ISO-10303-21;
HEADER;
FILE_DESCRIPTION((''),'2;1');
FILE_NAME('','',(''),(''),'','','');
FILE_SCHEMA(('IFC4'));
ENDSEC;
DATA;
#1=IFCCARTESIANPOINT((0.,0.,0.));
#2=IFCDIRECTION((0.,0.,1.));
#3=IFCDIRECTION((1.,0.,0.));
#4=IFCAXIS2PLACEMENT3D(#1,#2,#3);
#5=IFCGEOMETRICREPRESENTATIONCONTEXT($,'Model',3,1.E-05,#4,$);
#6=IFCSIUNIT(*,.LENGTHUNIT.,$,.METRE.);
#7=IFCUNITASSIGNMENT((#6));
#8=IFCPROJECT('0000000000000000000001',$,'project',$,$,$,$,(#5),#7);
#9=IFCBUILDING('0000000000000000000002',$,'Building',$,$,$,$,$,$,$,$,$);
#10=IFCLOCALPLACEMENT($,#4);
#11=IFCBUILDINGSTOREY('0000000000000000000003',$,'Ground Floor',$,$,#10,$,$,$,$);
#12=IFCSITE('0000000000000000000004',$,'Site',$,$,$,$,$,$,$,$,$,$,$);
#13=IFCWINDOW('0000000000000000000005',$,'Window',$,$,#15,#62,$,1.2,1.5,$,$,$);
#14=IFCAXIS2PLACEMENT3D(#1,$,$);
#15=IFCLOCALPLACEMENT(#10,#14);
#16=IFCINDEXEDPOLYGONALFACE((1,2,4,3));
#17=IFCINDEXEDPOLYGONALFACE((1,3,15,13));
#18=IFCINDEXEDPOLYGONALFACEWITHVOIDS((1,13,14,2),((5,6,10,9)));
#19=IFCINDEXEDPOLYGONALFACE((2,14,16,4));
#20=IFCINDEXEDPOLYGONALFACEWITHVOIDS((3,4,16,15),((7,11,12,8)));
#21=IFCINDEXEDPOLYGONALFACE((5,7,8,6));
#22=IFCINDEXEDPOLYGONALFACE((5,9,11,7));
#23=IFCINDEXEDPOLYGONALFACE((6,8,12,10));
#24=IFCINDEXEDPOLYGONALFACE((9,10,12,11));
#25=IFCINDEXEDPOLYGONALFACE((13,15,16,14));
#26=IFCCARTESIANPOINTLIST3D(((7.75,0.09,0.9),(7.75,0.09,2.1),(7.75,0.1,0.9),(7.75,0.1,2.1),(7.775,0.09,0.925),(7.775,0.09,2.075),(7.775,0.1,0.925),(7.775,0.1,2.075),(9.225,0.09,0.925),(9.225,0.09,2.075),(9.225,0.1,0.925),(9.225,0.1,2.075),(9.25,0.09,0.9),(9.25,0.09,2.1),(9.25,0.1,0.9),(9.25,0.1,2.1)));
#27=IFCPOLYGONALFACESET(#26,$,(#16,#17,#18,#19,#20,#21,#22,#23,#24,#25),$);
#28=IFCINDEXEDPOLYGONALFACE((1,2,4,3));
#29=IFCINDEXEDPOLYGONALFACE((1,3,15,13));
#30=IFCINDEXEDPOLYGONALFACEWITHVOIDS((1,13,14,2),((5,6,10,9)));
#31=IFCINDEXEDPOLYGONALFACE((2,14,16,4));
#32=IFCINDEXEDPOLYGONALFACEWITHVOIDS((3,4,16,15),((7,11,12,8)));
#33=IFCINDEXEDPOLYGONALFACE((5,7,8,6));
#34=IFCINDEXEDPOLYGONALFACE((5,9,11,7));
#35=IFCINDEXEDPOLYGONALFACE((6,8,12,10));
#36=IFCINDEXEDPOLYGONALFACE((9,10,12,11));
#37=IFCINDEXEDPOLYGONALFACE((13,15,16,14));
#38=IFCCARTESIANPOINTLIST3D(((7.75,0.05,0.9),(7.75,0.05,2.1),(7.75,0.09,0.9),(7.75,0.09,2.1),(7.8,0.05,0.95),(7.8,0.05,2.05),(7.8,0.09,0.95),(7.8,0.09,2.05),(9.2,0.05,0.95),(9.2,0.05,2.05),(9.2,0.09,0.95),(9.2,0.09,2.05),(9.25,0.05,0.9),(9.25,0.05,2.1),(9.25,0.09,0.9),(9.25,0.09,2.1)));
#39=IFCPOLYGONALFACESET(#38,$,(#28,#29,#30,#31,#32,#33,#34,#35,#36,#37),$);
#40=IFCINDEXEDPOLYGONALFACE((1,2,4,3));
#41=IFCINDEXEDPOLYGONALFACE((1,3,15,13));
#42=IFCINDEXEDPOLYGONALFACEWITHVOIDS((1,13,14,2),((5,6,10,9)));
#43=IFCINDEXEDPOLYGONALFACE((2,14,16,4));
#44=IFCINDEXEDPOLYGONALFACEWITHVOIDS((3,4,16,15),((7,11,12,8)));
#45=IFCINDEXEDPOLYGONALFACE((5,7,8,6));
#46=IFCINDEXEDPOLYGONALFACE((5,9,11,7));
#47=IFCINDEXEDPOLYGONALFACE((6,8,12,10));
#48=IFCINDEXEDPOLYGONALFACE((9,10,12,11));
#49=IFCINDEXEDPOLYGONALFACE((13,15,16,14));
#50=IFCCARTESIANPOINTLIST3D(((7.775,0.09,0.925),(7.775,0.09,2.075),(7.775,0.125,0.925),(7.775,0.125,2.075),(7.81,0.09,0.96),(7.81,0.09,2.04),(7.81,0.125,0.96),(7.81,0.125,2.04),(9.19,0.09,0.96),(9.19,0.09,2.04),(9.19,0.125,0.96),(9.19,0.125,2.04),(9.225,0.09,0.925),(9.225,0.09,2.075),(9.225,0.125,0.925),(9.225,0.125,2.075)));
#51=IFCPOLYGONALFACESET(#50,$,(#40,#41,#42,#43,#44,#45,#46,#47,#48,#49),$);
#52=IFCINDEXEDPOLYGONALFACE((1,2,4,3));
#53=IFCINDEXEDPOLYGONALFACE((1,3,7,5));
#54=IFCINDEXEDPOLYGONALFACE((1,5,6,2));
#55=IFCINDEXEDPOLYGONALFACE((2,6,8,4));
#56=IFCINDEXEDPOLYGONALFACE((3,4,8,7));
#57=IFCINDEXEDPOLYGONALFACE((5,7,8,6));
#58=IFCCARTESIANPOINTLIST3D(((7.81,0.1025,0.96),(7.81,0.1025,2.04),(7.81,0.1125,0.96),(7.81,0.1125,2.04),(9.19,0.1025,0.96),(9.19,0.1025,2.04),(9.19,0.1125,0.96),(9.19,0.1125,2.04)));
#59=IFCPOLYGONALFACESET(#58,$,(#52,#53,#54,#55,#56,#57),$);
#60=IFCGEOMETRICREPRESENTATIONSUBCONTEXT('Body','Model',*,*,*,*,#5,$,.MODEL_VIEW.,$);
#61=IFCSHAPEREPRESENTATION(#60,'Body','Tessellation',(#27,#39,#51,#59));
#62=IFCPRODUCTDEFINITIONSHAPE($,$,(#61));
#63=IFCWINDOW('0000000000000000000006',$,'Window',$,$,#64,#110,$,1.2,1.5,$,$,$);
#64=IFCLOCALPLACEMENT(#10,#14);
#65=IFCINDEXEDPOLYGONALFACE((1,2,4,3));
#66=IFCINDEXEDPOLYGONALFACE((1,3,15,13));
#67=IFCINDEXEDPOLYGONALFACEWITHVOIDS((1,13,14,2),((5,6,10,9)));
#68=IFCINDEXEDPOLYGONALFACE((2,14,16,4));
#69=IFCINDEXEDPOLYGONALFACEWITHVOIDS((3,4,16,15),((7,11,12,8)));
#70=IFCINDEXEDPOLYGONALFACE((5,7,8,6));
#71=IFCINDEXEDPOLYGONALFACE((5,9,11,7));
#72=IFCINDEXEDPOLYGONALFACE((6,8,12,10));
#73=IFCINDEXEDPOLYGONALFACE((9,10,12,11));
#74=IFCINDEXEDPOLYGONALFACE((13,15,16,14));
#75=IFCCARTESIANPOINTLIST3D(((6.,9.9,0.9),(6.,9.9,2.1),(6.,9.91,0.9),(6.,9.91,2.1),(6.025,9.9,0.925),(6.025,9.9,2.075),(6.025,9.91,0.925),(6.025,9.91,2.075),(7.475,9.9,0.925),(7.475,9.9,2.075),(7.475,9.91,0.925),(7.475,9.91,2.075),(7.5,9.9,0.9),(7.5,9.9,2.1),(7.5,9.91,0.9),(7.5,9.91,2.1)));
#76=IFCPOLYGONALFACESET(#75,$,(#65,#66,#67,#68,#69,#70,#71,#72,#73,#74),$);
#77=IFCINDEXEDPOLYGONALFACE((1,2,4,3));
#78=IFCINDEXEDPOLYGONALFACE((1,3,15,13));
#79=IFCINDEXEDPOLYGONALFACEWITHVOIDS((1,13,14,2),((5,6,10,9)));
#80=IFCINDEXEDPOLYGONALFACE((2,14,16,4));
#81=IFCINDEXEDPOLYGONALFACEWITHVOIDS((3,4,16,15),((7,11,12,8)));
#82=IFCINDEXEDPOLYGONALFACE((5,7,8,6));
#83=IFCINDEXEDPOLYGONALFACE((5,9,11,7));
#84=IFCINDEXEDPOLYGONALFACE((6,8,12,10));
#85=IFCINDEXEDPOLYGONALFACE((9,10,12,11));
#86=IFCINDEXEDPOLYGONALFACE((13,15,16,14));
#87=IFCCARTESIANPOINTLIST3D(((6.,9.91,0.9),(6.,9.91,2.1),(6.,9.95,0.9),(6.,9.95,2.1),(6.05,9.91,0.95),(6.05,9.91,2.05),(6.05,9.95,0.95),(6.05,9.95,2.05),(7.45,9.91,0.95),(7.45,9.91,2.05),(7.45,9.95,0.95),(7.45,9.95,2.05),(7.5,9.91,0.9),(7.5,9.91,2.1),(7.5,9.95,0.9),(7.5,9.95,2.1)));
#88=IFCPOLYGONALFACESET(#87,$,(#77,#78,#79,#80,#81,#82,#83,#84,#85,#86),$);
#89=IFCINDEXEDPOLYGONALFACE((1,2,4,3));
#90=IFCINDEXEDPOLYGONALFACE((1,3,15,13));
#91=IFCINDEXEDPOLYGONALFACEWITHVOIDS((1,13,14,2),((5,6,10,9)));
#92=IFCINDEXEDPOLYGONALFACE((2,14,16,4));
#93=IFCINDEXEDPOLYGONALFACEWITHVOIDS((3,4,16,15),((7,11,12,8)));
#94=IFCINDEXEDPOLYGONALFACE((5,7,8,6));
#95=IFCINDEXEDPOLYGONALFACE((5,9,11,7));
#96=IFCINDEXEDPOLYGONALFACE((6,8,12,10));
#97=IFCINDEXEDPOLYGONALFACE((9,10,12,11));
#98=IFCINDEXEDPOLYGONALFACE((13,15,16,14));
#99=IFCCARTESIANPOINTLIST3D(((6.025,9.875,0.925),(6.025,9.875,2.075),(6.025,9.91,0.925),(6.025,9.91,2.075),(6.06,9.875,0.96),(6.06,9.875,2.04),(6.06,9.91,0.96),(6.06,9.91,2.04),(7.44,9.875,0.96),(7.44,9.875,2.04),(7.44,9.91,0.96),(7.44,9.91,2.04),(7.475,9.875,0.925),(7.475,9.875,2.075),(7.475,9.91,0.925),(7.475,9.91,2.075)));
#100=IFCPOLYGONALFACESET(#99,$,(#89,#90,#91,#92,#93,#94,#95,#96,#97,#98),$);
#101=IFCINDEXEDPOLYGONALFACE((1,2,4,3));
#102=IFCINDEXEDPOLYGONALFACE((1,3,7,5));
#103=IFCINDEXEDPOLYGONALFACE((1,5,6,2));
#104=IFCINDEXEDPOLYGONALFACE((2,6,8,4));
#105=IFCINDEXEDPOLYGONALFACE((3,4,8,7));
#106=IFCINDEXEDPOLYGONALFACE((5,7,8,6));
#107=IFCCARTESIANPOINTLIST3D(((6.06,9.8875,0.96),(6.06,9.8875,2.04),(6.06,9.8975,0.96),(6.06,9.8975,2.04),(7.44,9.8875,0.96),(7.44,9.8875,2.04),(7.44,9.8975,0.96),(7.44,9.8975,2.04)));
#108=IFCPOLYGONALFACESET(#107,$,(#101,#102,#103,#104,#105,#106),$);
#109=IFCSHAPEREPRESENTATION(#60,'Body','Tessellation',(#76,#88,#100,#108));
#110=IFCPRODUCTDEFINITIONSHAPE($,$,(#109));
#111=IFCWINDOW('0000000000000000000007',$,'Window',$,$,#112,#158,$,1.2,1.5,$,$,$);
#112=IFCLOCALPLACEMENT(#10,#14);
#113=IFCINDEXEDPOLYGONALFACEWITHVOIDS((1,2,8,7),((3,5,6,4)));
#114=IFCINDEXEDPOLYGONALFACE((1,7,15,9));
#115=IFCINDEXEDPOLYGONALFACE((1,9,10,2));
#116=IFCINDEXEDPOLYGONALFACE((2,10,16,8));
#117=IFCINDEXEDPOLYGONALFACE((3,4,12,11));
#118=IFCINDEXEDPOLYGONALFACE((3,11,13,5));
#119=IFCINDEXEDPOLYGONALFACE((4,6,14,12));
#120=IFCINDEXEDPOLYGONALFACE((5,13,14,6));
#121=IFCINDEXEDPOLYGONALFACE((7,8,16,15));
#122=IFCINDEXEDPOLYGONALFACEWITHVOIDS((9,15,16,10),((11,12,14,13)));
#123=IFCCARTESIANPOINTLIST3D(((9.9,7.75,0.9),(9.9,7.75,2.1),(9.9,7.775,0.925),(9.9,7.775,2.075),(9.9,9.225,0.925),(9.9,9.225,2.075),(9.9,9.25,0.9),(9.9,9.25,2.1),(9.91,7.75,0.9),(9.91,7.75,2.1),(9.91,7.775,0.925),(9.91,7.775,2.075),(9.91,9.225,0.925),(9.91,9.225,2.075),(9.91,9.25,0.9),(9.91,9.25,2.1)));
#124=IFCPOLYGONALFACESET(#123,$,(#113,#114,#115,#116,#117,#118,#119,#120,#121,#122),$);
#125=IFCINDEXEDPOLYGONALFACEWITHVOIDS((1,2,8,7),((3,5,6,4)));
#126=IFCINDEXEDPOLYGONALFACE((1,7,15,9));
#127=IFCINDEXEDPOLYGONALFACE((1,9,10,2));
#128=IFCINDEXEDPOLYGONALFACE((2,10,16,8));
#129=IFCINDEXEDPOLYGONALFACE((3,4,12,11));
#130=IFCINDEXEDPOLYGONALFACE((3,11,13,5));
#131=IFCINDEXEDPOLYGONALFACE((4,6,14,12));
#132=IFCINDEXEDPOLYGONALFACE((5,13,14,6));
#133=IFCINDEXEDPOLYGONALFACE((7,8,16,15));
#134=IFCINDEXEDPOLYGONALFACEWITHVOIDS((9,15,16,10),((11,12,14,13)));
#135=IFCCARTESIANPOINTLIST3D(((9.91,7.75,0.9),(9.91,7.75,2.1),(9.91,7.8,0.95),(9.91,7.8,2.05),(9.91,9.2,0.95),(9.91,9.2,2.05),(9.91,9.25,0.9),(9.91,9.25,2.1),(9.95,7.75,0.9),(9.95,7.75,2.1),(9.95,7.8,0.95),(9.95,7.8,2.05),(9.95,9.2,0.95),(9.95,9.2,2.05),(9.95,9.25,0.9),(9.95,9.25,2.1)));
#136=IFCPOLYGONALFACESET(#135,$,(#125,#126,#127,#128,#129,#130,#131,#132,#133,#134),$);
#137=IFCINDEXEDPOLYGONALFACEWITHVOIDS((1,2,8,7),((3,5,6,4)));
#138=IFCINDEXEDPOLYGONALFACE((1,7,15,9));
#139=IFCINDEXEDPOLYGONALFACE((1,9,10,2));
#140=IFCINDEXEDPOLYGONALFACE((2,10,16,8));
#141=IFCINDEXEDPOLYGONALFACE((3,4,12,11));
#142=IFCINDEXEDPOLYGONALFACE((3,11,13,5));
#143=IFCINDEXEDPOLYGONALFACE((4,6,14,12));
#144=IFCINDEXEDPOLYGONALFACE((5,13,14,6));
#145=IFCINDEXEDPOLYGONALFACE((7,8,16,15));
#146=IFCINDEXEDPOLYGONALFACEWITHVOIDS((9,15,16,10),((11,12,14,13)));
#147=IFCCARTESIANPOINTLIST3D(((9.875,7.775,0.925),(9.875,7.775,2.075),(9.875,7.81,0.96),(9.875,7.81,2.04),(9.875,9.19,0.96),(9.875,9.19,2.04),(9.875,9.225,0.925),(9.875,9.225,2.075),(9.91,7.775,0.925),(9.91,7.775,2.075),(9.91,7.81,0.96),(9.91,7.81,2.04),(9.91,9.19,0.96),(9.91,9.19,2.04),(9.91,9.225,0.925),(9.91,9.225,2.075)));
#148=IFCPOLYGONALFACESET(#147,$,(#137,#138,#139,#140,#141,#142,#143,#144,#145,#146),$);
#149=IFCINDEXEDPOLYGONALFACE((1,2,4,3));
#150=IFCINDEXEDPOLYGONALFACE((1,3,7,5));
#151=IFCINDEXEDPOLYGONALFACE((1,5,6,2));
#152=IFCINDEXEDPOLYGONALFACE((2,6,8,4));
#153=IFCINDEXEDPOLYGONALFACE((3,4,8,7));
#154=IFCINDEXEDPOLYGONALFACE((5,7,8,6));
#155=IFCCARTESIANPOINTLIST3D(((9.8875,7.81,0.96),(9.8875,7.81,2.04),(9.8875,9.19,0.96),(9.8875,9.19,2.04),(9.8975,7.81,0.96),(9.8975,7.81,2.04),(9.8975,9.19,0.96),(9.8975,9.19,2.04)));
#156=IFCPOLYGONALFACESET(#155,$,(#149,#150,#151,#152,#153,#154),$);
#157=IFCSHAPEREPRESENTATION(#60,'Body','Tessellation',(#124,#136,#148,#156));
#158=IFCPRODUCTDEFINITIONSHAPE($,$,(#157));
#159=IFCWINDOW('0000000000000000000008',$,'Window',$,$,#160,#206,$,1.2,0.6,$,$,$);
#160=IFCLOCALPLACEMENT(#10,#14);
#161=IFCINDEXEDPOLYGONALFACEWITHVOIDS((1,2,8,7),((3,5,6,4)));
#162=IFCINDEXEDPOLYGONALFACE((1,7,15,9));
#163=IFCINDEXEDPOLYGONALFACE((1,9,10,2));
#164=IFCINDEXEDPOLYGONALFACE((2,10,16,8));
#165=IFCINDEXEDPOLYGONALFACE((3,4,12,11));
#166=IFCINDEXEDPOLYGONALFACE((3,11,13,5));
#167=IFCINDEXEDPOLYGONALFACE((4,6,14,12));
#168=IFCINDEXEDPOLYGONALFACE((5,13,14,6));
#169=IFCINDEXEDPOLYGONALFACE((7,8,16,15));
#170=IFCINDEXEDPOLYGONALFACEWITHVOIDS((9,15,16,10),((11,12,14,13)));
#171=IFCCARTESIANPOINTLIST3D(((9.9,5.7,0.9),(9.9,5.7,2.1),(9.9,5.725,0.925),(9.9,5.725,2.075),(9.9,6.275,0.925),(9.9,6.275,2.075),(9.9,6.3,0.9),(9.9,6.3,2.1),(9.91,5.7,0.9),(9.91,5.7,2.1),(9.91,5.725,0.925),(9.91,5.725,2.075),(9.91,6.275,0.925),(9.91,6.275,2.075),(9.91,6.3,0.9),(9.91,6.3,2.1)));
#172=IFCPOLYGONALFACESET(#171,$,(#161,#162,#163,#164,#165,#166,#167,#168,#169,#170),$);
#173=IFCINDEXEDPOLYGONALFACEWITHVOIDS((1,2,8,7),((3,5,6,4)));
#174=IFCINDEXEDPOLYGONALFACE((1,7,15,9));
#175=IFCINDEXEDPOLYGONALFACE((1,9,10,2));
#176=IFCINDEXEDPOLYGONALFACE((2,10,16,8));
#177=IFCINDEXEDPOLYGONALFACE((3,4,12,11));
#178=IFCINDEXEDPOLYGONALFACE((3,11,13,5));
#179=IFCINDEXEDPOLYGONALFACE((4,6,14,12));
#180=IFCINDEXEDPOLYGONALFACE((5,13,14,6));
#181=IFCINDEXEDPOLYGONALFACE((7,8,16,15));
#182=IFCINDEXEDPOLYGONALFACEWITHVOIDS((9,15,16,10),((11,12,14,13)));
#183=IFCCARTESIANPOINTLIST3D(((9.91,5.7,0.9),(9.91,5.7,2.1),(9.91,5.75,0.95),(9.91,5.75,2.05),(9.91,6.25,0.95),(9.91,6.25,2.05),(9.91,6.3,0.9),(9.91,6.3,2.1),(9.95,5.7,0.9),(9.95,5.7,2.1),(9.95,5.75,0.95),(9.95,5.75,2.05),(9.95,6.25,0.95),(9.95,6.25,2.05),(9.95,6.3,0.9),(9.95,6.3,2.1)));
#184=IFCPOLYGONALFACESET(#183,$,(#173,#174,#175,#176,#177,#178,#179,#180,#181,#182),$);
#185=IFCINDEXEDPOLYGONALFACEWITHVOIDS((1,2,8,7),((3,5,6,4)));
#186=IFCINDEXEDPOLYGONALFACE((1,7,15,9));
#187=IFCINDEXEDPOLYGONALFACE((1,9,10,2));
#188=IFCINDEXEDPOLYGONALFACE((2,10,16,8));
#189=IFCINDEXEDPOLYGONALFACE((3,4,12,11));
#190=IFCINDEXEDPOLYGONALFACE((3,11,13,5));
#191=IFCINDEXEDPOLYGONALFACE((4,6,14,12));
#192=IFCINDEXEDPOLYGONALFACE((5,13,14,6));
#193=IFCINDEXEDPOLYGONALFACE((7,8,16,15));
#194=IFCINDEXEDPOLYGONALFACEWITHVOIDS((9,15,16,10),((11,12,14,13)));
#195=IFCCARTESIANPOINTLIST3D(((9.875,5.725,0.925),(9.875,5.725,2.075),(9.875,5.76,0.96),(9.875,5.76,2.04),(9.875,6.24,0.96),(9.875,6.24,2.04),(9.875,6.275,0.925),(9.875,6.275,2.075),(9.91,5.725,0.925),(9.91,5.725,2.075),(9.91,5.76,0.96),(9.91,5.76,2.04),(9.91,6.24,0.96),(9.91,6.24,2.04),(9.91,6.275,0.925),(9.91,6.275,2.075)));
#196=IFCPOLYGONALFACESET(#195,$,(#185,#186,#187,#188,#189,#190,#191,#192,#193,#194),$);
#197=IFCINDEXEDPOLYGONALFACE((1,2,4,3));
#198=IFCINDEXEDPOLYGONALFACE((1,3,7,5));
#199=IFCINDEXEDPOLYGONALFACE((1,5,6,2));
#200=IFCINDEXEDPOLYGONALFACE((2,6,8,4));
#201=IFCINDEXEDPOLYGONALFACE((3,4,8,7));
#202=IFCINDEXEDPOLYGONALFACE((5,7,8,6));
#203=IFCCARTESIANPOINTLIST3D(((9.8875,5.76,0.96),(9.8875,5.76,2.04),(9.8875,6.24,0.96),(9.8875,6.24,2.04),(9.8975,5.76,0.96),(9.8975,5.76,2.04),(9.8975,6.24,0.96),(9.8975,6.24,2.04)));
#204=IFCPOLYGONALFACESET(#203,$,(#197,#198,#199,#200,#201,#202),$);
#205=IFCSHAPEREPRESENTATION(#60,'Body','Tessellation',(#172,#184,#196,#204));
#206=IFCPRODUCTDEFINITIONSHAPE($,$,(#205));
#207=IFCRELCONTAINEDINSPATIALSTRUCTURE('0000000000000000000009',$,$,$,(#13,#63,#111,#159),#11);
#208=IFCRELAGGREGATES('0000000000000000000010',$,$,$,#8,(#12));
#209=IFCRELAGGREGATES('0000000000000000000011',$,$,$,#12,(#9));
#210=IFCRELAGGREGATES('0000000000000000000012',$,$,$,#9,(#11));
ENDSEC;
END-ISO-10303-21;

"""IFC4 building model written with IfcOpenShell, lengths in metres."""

from ifc_helpers import new_model, si_unit, frame, origin_with_axes, place, context, subcontext, project, spatial, line, indexed_curve, outline, extrude, element, save


model = new_model("IFC4")

# Units and contexts
model_context = context("Model", 3, precision=1e-05, world=origin_with_axes())
body_context = subcontext(model_context, "Body", "Model", "MODEL_VIEW")
ifc_project = project(units=[si_unit("LENGTHUNIT", "METRE")], contexts=[model_context])

# Site, building, storey
site = spatial("IfcSite", under=ifc_project, Name="Site")
building = spatial("IfcBuilding", under=site, Name="Building")
storey_placement = place(None, origin_with_axes())
storey = spatial("IfcBuildingStorey", under=building, at=storey_placement, Name="Ground Floor")

# Windows
for number, where, z_axis, x_axis, name in (
    (1, (7.75, 0.0, 0.9), (0.0, 0.0, 1.0), (1.0, 0.0, 0.0), "Window"),
    (2, (7.5, 10.0, 0.9), (0.0, 0.0, 1.0), (-1.0, 0.0, 0.0), "Window"),
    (3, (10.0, 7.75, 0.9), (0.0, 0.0, 1.0), (0.0, 1.0, 0.0), "Window"),
):
    element("IfcWindow", number, at=place(storey_placement, frame(where, z_axis=z_axis, x_axis=x_axis)), inside=storey, Name=name, OverallHeight=1.2, OverallWidth=1.5, context=body_context, shape_type="SweptSolid", body=[
        extrude(outline(indexed_curve([(0.0, 0.0), (1.5, 0.0), (1.5, 1.2), (0.0, 1.2)], segments=[line(1, 2, 3, 4, 1)]), holes=[indexed_curve([(0.025, 0.025), (1.475, 0.025), (1.475, 1.175), (0.025, 1.175)], segments=[line(1, 2, 3, 4, 1)])]), frame((0.0, 0.09, 0.0), z_axis=(0.0, -1.0, 0.0), x_axis=(1.0, 0.0, 0.0)), (0.0, 0.0, -1.0), 0.01),
        extrude(outline(indexed_curve([(0.0, 0.0), (1.5, 0.0), (1.5, 1.2), (0.0, 1.2)], segments=[line(1, 2, 3, 4, 1)]), holes=[indexed_curve([(0.05, 0.05), (1.45, 0.05), (1.45, 1.15), (0.05, 1.15)], segments=[line(1, 2, 3, 4, 1)])]), frame((0.0, 0.05, 0.0), z_axis=(0.0, -1.0, 0.0), x_axis=(1.0, 0.0, 0.0)), (0.0, 0.0, -1.0), 0.04),
        extrude(outline(indexed_curve([(0.0, 0.0), (1.45, 0.0), (1.45, 1.15), (0.0, 1.15)], segments=[line(1, 2, 3, 4, 1)]), holes=[indexed_curve([(0.035, 0.035), (1.415, 0.035), (1.415, 1.115), (0.035, 1.115)], segments=[line(1, 2, 3, 4, 1)])]), frame((0.025, 0.09, 0.025), z_axis=(0.0, -1.0, 0.0), x_axis=(1.0, 0.0, 0.0)), (0.0, 0.0, -1.0), 0.035),
        extrude(outline(indexed_curve([(0.035, 0.035), (1.415, 0.035), (1.415, 1.115), (0.035, 1.115)], segments=[line(1, 2, 3, 4, 1)])), frame((0.025, 0.1025, 0.025), z_axis=(0.0, -1.0, 0.0), x_axis=(1.0, 0.0, 0.0)), (0.0, 0.0, -1.0), 0.01),
    ])
window_placement = place(storey_placement, frame((10.0, 5.7, 0.9), z_axis=(0.0, 0.0, 1.0), x_axis=(0.0, 1.0, 0.0)))
element("IfcWindow", 4, at=window_placement, inside=storey, Name="Window", OverallHeight=1.2, OverallWidth=0.6, context=body_context, shape_type="SweptSolid", body=[
    extrude(outline(indexed_curve([(0.0, 0.0), (0.6, 0.0), (0.6, 1.2), (0.0, 1.2)], segments=[line(1, 2, 3, 4, 1)]), holes=[indexed_curve([(0.025, 0.025), (0.575, 0.025), (0.575, 1.175), (0.025, 1.175)], segments=[line(1, 2, 3, 4, 1)])]), frame((0.0, 0.09, 0.0), z_axis=(0.0, -1.0, 0.0), x_axis=(1.0, 0.0, 0.0)), (0.0, 0.0, -1.0), 0.01),
    extrude(outline(indexed_curve([(0.0, 0.0), (0.6, 0.0), (0.6, 1.2), (0.0, 1.2)], segments=[line(1, 2, 3, 4, 1)]), holes=[indexed_curve([(0.05, 0.05), (0.55, 0.05), (0.55, 1.15), (0.05, 1.15)], segments=[line(1, 2, 3, 4, 1)])]), frame((0.0, 0.05, 0.0), z_axis=(0.0, -1.0, 0.0), x_axis=(1.0, 0.0, 0.0)), (0.0, 0.0, -1.0), 0.04),
    extrude(outline(indexed_curve([(0.0, 0.0), (0.55, 0.0), (0.55, 1.15), (0.0, 1.15)], segments=[line(1, 2, 3, 4, 1)]), holes=[indexed_curve([(0.035, 0.035), (0.515, 0.035), (0.515, 1.115), (0.035, 1.115)], segments=[line(1, 2, 3, 4, 1)])]), frame((0.025, 0.09, 0.025), z_axis=(0.0, -1.0, 0.0), x_axis=(1.0, 0.0, 0.0)), (0.0, 0.0, -1.0), 0.035),
    extrude(outline(indexed_curve([(0.035, 0.035), (0.515, 0.035), (0.515, 1.115), (0.035, 1.115)], segments=[line(1, 2, 3, 4, 1)])), frame((0.025, 0.1025, 0.025), z_axis=(0.0, -1.0, 0.0), x_axis=(1.0, 0.0, 0.0)), (0.0, 0.0, -1.0), 0.01),
])

save(model, "model.ifc")
